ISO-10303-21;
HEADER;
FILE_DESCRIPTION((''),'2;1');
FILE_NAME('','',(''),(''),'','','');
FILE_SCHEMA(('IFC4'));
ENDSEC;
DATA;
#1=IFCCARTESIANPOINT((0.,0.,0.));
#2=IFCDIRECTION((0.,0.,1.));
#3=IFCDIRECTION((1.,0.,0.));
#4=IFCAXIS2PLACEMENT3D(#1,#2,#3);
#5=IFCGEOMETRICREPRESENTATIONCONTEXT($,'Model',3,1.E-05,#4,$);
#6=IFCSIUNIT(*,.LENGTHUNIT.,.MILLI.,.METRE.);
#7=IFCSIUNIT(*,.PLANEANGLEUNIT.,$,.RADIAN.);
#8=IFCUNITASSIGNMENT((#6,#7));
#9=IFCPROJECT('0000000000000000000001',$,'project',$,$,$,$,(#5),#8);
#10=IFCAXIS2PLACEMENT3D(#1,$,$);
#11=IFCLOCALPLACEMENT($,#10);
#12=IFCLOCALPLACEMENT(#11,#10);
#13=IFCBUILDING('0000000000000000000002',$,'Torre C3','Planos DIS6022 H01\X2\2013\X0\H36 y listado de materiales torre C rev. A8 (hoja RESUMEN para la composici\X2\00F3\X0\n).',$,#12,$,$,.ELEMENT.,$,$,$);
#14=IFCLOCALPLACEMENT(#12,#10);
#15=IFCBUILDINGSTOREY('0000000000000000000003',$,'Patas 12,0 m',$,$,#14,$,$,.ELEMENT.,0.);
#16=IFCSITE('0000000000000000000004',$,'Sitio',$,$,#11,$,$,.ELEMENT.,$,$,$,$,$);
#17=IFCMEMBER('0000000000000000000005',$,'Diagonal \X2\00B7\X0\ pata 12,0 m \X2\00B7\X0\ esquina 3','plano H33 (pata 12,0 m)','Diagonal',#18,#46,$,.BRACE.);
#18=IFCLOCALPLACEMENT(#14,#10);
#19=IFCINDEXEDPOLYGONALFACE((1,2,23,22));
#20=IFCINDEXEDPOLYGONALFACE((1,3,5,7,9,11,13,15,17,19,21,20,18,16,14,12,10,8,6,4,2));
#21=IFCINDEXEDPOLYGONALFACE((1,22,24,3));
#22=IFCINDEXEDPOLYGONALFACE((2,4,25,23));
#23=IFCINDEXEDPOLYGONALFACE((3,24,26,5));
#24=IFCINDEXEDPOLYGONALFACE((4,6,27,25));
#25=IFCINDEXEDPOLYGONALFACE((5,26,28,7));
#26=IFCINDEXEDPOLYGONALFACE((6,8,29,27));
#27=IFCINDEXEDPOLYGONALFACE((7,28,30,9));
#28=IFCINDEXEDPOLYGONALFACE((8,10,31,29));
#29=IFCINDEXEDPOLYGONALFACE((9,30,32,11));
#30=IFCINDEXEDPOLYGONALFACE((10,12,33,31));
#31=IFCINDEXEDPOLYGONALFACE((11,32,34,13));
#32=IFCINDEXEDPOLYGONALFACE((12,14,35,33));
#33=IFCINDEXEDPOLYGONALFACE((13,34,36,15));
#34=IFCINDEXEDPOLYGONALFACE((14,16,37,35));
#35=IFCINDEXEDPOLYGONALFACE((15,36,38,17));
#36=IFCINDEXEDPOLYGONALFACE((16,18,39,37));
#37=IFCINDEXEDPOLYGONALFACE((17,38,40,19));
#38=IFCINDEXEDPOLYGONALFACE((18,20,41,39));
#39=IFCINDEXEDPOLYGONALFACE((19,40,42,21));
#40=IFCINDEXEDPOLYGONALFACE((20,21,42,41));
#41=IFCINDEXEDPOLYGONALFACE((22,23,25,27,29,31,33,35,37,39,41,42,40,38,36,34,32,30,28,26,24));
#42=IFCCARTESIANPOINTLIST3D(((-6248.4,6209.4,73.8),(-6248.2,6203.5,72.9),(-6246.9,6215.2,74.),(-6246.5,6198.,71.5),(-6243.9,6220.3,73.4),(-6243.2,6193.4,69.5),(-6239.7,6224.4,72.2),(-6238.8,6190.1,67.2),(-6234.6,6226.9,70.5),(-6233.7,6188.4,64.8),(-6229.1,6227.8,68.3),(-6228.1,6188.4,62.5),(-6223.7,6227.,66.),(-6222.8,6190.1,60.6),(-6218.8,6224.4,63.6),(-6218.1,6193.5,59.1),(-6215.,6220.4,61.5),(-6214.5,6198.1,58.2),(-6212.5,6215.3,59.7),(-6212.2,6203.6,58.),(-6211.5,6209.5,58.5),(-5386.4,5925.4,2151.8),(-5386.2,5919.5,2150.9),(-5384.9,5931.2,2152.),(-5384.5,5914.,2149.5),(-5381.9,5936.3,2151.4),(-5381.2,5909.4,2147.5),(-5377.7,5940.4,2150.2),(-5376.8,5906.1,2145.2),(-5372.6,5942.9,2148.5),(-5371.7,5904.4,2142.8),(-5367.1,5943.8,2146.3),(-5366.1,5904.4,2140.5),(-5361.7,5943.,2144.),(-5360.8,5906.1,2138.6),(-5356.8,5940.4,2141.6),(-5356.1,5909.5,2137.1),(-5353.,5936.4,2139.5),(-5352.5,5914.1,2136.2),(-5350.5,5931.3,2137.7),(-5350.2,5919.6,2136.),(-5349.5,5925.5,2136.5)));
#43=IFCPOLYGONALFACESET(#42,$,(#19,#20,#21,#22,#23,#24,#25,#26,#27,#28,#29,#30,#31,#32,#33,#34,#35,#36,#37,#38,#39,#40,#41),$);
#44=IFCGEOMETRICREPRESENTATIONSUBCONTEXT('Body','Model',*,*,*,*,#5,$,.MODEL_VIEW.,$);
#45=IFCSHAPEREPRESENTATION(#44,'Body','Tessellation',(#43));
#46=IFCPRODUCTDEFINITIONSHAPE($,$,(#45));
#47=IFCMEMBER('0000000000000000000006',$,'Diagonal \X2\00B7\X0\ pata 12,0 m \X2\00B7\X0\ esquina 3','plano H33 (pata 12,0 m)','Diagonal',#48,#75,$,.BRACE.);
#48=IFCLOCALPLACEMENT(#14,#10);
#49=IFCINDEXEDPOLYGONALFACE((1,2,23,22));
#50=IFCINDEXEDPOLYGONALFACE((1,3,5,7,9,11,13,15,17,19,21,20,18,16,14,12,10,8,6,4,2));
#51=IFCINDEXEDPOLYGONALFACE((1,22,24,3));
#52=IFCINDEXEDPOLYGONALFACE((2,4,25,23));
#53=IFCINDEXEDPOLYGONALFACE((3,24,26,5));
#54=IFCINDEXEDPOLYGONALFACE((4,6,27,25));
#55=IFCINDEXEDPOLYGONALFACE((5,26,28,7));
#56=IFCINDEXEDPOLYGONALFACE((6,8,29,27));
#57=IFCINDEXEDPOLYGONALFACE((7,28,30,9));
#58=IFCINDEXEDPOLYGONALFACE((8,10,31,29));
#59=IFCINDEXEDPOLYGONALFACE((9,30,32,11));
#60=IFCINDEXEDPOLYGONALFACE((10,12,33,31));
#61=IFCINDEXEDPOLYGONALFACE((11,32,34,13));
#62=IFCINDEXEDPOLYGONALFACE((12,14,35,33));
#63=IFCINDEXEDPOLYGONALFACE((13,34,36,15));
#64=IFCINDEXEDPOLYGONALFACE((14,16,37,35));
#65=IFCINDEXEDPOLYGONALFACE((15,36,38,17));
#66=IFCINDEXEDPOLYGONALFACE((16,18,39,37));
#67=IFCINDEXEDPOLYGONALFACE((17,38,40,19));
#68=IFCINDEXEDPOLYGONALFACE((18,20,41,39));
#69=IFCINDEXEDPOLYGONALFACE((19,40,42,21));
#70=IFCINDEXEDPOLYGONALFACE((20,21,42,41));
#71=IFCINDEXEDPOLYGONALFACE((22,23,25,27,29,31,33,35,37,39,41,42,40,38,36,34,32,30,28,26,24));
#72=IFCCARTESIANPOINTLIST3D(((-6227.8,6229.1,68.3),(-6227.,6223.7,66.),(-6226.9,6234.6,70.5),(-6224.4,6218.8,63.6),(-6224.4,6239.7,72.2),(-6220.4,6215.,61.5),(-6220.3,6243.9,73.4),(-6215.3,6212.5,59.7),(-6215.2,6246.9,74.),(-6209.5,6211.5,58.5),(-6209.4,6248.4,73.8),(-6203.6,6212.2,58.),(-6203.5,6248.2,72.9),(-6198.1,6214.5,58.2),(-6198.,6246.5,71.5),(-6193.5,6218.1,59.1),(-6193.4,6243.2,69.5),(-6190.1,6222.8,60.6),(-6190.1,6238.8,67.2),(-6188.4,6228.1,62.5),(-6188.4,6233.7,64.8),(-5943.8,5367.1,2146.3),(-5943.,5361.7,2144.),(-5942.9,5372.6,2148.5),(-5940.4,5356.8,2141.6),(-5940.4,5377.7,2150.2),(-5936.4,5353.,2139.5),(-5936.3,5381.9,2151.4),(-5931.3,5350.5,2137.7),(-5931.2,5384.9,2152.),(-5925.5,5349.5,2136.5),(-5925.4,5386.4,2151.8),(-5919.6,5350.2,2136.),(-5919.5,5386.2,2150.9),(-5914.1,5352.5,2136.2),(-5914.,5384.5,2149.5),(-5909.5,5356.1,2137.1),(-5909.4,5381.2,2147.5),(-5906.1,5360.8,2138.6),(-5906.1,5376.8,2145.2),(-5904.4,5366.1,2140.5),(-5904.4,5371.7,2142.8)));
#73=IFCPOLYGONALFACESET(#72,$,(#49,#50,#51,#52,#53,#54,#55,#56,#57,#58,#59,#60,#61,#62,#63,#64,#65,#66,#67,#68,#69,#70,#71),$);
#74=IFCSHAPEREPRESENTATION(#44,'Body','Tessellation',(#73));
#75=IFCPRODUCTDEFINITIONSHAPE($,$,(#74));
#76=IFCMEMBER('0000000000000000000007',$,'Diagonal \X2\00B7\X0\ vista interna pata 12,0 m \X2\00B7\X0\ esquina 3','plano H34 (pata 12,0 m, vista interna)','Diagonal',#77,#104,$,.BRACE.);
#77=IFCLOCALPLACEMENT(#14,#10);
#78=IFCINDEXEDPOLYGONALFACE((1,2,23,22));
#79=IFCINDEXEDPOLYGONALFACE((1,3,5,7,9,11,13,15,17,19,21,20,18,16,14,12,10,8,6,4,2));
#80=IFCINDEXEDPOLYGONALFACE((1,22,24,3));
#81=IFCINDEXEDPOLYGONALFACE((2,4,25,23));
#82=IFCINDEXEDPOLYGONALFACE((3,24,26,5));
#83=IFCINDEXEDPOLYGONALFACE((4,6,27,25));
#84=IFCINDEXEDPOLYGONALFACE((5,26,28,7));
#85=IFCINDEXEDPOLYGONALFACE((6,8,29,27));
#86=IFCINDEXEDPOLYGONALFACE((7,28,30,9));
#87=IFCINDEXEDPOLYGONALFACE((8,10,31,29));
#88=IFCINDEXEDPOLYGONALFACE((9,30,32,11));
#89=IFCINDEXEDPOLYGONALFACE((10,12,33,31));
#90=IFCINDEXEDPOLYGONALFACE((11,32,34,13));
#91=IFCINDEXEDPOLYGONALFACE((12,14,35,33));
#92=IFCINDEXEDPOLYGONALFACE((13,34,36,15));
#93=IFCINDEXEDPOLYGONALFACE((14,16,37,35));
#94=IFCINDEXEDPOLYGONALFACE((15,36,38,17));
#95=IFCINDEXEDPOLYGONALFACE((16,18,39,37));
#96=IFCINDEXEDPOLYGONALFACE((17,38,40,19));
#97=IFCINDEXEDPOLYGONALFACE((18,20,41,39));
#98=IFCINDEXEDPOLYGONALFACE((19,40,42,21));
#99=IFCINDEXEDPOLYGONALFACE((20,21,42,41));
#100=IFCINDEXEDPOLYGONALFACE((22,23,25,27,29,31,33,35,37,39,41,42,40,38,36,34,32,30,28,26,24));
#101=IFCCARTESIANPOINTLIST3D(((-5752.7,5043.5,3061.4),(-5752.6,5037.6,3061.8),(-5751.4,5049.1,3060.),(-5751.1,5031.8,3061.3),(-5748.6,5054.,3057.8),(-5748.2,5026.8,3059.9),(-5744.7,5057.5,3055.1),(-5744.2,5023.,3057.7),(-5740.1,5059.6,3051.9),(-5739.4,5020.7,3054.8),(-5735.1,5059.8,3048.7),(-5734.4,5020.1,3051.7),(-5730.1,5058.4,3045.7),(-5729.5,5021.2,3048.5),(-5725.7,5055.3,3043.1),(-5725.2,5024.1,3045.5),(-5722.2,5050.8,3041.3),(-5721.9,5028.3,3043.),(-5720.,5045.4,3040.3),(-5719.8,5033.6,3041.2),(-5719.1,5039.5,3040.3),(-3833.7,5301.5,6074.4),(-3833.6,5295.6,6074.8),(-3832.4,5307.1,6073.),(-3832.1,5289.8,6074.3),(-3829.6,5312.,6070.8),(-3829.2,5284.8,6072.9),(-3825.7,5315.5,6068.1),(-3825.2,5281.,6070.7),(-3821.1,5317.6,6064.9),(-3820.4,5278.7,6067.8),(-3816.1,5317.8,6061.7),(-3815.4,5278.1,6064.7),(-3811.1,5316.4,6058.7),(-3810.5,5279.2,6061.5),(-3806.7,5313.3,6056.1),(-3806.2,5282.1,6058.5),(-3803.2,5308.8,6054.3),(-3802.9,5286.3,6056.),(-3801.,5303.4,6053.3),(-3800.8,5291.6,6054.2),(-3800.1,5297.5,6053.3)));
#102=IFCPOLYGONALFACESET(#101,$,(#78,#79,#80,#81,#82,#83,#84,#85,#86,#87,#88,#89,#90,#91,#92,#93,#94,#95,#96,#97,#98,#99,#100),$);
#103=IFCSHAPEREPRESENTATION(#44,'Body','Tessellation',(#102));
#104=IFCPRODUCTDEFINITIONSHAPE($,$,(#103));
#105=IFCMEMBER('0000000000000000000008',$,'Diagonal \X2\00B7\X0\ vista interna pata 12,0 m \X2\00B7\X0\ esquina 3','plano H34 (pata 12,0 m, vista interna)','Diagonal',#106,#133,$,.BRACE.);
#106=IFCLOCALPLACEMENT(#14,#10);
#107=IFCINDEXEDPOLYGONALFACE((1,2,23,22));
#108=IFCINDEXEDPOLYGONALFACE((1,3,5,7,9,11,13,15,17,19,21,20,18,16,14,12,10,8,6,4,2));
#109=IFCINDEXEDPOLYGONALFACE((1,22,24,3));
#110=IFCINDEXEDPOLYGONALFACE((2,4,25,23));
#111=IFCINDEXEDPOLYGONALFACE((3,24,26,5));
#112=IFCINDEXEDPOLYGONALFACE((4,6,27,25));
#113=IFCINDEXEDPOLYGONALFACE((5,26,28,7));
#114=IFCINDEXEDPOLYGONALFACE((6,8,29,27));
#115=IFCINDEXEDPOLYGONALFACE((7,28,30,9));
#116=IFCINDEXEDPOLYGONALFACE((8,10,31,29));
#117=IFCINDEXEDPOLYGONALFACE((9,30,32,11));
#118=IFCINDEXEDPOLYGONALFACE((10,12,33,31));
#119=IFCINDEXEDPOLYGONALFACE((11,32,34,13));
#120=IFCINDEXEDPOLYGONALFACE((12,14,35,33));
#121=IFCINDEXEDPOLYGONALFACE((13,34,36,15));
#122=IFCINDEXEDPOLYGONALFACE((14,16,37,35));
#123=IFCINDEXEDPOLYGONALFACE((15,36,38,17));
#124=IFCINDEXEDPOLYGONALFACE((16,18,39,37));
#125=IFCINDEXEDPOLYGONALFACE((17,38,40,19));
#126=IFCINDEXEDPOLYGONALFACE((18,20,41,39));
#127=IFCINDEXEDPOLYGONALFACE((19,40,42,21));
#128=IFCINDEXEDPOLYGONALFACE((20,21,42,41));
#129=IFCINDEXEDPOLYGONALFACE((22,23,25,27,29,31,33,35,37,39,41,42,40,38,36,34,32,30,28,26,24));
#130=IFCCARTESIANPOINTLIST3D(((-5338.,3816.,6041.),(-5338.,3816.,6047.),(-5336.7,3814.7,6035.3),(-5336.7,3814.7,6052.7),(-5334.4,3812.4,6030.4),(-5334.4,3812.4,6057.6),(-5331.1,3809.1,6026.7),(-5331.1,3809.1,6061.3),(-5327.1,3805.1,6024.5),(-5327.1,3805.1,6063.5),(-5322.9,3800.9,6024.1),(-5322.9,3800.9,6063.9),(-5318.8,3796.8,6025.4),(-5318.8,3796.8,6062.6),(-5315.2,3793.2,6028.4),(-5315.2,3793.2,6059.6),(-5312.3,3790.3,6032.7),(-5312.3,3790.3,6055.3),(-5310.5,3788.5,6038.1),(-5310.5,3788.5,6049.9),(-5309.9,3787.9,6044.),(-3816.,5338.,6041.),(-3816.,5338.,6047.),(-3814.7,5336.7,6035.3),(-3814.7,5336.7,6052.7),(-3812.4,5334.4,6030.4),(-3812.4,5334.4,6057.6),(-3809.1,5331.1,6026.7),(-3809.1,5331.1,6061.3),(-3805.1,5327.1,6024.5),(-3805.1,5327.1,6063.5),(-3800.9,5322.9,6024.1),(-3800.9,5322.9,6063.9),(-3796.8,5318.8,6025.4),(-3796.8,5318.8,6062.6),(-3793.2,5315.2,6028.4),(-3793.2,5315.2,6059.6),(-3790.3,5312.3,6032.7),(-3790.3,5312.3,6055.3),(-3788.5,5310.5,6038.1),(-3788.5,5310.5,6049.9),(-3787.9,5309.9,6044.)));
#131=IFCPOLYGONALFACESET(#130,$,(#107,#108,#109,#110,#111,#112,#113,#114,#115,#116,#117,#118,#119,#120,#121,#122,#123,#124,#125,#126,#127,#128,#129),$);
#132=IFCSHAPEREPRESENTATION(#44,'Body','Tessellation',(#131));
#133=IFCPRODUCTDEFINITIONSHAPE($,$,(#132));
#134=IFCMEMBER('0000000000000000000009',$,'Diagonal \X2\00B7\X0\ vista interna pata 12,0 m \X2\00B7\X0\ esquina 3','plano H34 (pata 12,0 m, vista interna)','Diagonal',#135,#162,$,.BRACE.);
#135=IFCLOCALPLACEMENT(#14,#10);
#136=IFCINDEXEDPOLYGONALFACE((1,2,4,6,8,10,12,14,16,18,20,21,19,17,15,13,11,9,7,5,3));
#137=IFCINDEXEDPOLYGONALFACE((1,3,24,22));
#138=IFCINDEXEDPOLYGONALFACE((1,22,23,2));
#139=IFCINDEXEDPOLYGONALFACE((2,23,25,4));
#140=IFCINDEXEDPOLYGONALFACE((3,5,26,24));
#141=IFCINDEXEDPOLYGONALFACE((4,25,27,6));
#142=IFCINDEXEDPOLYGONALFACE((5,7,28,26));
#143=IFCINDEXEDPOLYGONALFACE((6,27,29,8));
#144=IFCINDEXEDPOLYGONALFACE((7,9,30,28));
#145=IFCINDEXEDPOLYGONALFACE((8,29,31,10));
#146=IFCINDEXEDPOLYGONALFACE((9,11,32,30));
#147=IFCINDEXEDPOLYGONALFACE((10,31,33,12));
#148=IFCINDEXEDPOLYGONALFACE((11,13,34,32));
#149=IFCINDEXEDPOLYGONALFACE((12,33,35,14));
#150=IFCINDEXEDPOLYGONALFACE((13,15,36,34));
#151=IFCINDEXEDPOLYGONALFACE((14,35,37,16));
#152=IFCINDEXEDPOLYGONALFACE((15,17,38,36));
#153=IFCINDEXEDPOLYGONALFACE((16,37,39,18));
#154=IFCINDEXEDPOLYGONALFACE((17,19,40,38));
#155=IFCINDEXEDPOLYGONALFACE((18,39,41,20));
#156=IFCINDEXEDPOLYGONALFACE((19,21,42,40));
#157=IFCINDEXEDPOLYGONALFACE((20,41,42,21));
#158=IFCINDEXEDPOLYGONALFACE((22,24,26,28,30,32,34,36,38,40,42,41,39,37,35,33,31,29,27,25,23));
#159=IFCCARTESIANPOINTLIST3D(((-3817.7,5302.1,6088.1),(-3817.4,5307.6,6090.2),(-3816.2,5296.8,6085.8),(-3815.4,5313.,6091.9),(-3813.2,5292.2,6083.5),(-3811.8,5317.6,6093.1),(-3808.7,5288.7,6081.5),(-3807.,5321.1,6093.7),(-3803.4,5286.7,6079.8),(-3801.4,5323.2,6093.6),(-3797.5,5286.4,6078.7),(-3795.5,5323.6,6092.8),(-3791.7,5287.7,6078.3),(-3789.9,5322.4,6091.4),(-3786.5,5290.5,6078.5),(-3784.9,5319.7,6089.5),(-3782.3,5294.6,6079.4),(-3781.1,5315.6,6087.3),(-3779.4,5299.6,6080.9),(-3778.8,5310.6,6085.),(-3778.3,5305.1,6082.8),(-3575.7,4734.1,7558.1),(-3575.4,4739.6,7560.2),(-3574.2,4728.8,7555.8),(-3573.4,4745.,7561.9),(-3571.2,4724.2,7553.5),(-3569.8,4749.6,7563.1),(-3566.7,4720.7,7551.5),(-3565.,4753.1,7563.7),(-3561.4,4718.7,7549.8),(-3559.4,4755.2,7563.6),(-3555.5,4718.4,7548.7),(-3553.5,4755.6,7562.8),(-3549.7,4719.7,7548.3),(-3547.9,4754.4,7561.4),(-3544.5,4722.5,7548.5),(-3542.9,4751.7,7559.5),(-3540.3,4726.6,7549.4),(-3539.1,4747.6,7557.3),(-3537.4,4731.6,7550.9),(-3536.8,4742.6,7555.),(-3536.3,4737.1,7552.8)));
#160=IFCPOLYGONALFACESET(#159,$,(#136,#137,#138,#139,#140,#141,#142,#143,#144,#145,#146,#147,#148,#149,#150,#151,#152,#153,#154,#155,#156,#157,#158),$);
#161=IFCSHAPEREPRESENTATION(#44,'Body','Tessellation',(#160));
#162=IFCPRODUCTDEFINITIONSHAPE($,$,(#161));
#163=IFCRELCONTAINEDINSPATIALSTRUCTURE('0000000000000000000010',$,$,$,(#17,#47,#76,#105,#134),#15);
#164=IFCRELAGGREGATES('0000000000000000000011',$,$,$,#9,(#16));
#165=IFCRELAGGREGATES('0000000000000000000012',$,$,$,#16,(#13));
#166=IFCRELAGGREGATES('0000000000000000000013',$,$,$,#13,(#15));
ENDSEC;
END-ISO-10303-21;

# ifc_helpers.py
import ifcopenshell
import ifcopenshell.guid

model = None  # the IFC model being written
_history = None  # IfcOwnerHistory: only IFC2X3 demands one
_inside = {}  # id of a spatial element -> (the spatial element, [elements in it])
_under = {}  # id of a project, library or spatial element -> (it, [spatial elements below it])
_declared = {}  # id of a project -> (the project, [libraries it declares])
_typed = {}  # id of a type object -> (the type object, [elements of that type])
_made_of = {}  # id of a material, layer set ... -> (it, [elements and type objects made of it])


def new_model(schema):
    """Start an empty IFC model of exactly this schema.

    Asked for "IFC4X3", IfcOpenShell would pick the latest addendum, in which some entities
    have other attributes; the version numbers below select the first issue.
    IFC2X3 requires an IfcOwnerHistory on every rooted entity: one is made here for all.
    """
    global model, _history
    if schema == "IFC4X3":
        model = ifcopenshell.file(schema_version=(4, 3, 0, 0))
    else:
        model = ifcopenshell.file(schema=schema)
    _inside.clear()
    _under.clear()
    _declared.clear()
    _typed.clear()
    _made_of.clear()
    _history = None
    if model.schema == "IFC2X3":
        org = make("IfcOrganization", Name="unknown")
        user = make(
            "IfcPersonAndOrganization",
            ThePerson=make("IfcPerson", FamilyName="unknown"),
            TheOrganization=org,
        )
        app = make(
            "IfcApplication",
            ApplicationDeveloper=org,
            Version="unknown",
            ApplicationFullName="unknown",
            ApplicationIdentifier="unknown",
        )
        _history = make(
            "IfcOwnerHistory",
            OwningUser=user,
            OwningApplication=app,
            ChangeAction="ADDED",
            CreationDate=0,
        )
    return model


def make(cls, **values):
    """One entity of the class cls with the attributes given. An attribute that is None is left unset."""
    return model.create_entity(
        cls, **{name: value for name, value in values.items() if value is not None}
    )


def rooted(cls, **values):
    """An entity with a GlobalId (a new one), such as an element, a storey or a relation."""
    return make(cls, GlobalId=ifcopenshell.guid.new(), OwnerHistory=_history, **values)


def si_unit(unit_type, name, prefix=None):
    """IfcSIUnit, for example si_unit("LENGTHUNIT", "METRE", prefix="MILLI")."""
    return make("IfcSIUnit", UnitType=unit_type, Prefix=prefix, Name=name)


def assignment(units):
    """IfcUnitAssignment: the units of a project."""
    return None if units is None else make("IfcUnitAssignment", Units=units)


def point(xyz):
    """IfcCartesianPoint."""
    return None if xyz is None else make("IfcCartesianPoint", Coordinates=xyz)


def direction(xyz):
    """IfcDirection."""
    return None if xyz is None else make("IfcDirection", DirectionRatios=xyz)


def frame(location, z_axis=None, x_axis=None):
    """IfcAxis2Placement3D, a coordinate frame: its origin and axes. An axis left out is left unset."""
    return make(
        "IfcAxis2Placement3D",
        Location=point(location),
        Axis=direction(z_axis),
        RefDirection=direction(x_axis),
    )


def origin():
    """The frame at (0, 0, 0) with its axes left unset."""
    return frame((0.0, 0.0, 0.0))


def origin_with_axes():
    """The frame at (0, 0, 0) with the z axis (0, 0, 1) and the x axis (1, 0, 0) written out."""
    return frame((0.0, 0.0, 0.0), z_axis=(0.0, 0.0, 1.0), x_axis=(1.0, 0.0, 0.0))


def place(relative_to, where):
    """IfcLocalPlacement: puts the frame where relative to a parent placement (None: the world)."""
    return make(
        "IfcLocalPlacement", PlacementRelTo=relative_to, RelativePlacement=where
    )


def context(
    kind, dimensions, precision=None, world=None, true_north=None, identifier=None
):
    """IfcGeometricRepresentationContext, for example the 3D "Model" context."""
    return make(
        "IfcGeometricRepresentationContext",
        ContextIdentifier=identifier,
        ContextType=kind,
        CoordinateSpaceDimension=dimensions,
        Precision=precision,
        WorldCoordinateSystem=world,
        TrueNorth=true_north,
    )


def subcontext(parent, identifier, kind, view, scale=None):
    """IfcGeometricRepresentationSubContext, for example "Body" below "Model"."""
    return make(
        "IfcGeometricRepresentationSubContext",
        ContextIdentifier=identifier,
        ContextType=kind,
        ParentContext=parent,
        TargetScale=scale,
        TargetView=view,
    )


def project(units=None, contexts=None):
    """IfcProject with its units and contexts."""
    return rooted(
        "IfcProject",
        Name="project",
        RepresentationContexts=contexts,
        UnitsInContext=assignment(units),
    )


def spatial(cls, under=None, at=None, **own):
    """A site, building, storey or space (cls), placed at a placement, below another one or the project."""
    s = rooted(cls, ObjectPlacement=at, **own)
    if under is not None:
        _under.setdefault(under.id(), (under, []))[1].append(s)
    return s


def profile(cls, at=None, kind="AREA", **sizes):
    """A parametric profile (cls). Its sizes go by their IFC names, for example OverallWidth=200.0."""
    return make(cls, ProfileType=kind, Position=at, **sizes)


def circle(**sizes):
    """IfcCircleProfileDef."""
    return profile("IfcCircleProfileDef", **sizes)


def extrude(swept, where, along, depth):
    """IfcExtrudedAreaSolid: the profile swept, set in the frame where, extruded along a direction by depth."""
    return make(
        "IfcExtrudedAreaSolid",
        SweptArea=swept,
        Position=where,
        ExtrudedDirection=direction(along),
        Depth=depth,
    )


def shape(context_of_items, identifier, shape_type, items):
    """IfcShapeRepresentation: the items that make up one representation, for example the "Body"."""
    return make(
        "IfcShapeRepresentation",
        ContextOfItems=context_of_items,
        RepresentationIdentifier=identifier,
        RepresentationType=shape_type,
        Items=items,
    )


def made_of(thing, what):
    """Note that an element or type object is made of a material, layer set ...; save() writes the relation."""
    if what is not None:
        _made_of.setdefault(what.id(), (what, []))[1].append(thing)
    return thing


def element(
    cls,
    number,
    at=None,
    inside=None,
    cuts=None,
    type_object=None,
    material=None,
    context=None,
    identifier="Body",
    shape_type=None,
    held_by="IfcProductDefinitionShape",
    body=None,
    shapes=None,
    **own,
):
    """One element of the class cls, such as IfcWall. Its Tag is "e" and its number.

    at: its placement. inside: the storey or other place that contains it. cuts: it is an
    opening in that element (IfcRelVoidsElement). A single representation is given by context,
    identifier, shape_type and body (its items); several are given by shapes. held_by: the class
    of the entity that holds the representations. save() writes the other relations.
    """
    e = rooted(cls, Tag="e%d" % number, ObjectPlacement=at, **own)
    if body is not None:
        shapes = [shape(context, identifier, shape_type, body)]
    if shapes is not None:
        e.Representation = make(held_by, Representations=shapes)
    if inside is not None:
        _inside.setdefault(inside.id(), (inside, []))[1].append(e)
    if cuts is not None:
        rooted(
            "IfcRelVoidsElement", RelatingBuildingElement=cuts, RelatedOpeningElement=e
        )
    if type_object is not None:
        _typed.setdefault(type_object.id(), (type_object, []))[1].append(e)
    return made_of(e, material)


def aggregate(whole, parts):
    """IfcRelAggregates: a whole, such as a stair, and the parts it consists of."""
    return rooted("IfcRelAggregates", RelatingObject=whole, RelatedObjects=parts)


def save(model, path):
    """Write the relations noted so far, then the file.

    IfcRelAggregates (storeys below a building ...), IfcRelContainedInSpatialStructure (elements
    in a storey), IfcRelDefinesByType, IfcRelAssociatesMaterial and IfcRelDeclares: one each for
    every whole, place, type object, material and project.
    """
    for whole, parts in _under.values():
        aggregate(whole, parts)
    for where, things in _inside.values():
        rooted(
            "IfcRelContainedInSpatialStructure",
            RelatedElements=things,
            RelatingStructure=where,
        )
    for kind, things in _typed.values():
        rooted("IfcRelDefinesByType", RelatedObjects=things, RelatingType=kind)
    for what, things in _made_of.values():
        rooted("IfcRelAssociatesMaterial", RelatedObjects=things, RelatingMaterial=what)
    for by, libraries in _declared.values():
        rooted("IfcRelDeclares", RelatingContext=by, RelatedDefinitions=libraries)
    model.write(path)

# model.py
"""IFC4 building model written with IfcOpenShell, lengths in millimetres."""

from ifc_helpers import new_model, si_unit, frame, origin, origin_with_axes, place, context, subcontext, project, spatial, circle, extrude, element, save


model = new_model("IFC4")

# Units and contexts
model_context = context("Model", 3, precision=1e-05, world=origin_with_axes())
body_context = subcontext(model_context, "Body", "Model", "MODEL_VIEW")
ifc_project = project(units=[si_unit("LENGTHUNIT", "METRE", prefix="MILLI"), si_unit("PLANEANGLEUNIT", "RADIAN")], contexts=[model_context])

# Site, building, storey
site_placement = place(None, origin())
site = spatial("IfcSite", under=ifc_project, at=site_placement, Name="Sitio", CompositionType="ELEMENT")
building_placement = place(site_placement, origin())
building = spatial("IfcBuilding", under=site, at=building_placement, Name="Torre C3", Description="Planos DIS6022 H01–H36 y listado de materiales torre C rev. A8 (hoja RESUMEN para la composición).", CompositionType="ELEMENT")
storey_placement = place(building_placement, origin())
storey = spatial("IfcBuildingStorey", under=building, at=storey_placement, Name="Patas 12,0 m", CompositionType="ELEMENT", Elevation=0.0)

# Members
for number, where, z_axis, x_axis, name in (
    (1, (-5368.0, 5924.0, 2144.0), (-0.380146, 0.125245, -0.916407), (0.595105, -0.725353, -0.345996), "Diagonal · pata 12,0 m · esquina 3"),
    (2, (-5924.0, 5368.0, 2144.0), (-0.125245, 0.380146, -0.916407), (0.725353, -0.595105, -0.345996), "Diagonal · pata 12,0 m · esquina 3"),
):
    element("IfcMember", number, at=place(storey_placement, frame(where, z_axis=z_axis, x_axis=x_axis)), inside=storey, Name=name, Description="plano H33 (pata 12,0 m)", ObjectType="Diagonal", PredefinedType="BRACE", context=body_context, shape_type="SweptSolid", body=[
        extrude(circle(Radius=20.0), None, (0.0, 0.0, 1.0), 2267.6),
    ])
member_1_placement = place(storey_placement, frame((-3817.0, 5298.0, 6064.0), z_axis=(-0.535806, -0.072036, -0.841263), x_axis=(0.538856, -0.79624, -0.27502)))
element("IfcMember", 3, at=member_1_placement, inside=storey, Name="Diagonal · vista interna pata 12,0 m · esquina 3", Description="plano H34 (pata 12,0 m, vista interna)", ObjectType="Diagonal", PredefinedType="BRACE", context=body_context, shape_type="SweptSolid", body=[
    extrude(circle(Radius=20.0), None, (0.0, 0.0, 1.0), 3581.5),
])
member_2_placement = place(storey_placement, frame((-3802.0, 5324.0, 6044.0), z_axis=(-0.707107, -0.707107, 0.0), x_axis=(0.707107, -0.707107, 0.0)))
element("IfcMember", 4, at=member_2_placement, inside=storey, Name="Diagonal · vista interna pata 12,0 m · esquina 3", Description="plano H34 (pata 12,0 m, vista interna)", ObjectType="Diagonal", PredefinedType="BRACE", context=body_context, shape_type="SweptSolid", body=[
    extrude(circle(Radius=20.0), None, (0.0, 0.0, 1.0), 2152.4),
])
member_3_placement = place(storey_placement, frame((-3798.0, 5305.0, 6086.0), z_axis=(0.151782, -0.356249, 0.921981), x_axis=(0.576131, -0.726055, -0.37539)))
element("IfcMember", 5, at=member_3_placement, inside=storey, Name="Diagonal · vista interna pata 12,0 m · esquina 3", Description="plano H34 (pata 12,0 m, vista interna)", ObjectType="Diagonal", PredefinedType="BRACE", context=body_context, shape_type="SweptSolid", body=[
    extrude(circle(Radius=20.0), None, (0.0, 0.0, 1.0), 1594.4),
])

save(model, "model.ifc")
